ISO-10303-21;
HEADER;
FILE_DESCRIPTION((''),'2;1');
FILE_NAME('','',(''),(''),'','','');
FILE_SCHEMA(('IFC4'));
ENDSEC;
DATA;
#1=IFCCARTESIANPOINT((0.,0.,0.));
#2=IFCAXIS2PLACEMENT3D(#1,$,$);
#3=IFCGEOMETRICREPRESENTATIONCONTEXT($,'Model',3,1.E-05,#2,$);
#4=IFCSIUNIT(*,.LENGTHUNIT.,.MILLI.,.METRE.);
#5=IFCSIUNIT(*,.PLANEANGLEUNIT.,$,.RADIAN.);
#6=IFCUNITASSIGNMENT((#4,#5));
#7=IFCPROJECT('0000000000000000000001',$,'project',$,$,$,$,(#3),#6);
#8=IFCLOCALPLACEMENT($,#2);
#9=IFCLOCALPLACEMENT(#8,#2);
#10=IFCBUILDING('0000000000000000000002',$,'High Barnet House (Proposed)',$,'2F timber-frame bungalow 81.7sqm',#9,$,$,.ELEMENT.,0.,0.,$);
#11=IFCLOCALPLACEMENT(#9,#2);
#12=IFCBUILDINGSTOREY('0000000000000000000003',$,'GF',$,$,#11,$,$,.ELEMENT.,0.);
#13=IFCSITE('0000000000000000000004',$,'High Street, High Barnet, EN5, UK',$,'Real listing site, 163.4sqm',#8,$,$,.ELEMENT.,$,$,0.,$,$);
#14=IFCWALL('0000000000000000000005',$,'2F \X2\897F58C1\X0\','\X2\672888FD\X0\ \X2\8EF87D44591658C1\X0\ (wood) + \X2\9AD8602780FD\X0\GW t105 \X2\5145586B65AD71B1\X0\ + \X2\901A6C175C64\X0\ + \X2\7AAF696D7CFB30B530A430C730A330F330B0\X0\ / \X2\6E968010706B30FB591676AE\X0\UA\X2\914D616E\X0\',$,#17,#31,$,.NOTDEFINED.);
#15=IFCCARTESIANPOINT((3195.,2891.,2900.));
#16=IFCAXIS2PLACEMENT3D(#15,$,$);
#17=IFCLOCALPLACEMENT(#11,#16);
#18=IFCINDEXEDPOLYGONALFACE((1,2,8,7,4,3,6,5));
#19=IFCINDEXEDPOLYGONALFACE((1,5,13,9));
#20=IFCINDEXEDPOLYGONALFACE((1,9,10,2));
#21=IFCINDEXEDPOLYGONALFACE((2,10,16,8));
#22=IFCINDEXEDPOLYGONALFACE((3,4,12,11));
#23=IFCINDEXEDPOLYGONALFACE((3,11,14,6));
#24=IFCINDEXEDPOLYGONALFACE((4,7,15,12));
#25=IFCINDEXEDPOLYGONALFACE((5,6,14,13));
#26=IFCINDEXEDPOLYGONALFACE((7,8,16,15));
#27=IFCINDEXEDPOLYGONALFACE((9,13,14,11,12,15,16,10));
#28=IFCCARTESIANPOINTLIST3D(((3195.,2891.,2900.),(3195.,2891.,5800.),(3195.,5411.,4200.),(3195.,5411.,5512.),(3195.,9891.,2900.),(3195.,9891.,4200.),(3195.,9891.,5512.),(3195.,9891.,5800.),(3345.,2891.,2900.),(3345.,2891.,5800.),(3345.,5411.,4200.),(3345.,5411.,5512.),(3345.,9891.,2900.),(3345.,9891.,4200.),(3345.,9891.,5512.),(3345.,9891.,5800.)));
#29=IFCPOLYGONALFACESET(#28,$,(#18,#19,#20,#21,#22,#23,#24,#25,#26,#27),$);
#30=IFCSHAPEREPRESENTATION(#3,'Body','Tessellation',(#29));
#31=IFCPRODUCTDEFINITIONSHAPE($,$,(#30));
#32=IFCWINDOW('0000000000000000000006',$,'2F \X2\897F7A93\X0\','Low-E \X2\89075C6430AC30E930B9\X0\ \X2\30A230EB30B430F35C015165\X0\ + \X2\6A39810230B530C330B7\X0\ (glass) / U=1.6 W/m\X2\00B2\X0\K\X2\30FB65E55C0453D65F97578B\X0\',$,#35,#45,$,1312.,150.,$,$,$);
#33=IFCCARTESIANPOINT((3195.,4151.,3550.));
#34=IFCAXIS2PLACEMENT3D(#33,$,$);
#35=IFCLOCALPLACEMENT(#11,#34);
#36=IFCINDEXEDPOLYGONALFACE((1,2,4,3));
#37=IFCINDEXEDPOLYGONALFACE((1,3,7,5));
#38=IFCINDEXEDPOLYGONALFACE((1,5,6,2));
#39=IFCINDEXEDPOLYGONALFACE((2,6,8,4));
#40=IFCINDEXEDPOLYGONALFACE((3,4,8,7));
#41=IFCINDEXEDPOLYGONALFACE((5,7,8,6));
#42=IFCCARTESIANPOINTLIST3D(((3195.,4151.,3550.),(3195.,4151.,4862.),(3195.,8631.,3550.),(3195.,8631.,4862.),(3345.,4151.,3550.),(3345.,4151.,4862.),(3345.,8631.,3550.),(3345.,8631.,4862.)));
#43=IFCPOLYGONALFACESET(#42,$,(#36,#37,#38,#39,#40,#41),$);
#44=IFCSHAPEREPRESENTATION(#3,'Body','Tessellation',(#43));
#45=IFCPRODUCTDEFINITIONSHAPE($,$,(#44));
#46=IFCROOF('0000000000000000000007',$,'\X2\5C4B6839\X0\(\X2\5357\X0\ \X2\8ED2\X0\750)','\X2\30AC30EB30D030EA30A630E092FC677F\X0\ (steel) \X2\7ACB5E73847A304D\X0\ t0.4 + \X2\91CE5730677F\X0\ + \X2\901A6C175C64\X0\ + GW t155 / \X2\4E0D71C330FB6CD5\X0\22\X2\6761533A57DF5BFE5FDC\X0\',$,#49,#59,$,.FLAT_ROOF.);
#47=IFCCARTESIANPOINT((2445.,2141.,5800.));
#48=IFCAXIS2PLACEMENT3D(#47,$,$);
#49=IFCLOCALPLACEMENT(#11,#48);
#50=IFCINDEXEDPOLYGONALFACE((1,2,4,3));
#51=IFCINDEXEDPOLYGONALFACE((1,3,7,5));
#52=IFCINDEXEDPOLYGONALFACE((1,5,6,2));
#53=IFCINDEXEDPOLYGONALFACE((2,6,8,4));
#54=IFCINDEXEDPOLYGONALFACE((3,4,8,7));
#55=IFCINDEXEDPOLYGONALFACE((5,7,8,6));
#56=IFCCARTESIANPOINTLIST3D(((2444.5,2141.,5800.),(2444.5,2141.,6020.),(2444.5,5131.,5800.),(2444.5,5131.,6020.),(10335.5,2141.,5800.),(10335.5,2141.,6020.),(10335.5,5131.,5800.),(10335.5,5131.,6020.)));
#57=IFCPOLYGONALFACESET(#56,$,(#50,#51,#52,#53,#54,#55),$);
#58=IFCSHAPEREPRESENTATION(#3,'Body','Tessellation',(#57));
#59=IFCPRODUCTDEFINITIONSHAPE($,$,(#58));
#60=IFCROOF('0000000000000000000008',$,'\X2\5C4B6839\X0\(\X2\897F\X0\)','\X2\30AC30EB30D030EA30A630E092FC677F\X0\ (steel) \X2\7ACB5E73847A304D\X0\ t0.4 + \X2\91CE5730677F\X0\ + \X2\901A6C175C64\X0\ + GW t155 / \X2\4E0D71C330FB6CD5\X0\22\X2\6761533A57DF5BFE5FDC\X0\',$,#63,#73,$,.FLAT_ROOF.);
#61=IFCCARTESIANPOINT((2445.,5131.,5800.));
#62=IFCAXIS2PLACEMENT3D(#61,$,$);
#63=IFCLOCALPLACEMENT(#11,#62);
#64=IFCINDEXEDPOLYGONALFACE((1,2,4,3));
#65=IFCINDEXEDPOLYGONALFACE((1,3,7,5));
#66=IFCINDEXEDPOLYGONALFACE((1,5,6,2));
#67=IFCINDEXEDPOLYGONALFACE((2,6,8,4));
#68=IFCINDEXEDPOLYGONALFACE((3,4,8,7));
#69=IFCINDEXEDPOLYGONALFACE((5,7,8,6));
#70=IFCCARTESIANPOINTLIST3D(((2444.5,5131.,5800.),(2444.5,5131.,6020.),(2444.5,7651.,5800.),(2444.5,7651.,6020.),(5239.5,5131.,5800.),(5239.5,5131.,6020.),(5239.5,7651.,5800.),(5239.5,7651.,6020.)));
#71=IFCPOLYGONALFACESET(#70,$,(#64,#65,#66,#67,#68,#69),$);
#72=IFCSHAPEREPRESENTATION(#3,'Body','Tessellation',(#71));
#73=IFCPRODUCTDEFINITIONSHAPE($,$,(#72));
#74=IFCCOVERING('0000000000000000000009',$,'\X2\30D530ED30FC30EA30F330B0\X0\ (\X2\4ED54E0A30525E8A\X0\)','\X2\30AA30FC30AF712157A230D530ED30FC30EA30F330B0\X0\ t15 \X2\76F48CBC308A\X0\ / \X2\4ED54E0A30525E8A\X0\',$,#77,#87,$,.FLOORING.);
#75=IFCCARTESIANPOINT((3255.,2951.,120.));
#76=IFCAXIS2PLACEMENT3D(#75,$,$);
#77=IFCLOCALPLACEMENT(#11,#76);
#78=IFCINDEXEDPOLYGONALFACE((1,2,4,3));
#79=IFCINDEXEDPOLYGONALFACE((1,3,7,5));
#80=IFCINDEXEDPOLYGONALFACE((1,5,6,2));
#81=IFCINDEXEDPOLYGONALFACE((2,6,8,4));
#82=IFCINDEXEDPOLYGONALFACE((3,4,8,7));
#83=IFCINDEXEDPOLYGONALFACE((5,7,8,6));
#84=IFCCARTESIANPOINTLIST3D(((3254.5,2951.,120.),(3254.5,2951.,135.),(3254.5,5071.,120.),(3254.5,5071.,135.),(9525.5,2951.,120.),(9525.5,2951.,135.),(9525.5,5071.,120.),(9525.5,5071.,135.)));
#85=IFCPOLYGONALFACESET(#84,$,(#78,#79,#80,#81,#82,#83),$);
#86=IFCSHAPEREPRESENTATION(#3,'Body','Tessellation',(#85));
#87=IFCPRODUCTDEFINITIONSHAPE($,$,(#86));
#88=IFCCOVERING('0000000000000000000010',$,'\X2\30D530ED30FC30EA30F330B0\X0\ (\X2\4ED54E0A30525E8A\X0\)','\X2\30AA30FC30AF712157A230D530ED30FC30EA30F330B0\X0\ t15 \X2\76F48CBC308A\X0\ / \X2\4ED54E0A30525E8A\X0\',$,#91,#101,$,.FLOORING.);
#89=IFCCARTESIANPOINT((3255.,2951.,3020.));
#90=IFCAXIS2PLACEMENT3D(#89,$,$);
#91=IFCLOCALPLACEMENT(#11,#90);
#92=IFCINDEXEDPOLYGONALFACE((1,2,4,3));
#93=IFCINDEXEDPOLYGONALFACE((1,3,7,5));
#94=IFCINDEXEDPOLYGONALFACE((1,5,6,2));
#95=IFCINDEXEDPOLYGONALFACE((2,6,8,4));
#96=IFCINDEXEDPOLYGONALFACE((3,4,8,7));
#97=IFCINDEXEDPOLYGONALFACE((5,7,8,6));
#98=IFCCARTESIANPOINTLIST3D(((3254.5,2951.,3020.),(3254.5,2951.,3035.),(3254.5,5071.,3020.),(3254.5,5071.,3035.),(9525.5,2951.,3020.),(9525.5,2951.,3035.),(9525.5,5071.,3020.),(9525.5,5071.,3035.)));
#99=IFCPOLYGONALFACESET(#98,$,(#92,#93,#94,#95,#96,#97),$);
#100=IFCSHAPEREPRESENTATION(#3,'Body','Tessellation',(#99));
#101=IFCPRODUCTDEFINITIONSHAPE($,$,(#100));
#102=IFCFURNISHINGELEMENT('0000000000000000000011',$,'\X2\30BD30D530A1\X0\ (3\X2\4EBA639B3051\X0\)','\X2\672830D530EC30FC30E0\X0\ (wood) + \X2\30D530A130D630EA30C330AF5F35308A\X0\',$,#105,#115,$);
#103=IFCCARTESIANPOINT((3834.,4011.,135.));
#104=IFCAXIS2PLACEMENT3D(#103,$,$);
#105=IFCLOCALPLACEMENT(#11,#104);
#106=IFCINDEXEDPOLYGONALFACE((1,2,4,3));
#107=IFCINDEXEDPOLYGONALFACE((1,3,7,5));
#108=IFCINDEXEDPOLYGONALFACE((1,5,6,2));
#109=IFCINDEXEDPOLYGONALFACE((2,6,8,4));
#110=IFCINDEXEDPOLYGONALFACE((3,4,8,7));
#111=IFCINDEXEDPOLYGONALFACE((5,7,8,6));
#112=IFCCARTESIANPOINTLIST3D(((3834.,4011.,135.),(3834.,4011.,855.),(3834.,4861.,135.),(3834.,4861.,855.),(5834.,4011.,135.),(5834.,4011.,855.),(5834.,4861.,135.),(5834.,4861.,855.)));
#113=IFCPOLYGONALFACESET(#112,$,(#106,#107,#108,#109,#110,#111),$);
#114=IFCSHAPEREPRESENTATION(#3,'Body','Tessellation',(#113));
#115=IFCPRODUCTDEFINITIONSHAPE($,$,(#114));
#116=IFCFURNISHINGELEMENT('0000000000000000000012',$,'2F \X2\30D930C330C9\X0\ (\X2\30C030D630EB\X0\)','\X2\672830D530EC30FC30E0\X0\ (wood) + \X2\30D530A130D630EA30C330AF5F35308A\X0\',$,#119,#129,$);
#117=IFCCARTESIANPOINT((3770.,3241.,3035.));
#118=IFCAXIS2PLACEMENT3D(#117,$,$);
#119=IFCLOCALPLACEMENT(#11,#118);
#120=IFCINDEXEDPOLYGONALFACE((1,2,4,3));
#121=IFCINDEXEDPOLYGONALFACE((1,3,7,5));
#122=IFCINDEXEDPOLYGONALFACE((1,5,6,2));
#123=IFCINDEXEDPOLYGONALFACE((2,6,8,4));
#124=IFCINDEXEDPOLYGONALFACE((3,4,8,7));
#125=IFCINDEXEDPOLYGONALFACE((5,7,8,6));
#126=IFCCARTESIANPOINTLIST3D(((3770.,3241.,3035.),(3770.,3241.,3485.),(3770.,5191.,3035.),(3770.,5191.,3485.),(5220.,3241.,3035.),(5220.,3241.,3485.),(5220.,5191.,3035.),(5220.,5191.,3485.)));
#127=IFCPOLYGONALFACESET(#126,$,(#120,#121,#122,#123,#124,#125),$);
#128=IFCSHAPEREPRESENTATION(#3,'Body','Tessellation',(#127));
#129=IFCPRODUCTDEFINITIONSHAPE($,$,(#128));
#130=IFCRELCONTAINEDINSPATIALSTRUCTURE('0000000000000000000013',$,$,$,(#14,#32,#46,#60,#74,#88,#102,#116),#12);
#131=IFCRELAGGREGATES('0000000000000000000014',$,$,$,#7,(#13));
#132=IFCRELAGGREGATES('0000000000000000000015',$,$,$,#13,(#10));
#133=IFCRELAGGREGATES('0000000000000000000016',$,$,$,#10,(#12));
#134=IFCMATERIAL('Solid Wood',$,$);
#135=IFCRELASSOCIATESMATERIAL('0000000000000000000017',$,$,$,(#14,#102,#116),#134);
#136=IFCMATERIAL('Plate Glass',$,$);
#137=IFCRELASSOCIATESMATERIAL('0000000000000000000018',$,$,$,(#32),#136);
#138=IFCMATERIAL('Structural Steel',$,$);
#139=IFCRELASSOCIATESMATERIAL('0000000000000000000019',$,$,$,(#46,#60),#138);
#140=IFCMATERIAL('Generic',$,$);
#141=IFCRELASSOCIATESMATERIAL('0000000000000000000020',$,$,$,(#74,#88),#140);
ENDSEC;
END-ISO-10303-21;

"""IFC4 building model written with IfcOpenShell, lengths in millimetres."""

from ifc_helpers import new_model, si_unit, frame, frame_2d, origin, place, context, project, spatial, rectangle, extrude, material, element, fill, save


model = new_model("IFC4")

# Units and contexts
model_context = context("Model", 3, precision=1e-05, world=origin())
ifc_project = project(units=[si_unit("LENGTHUNIT", "METRE", prefix="MILLI"), si_unit("PLANEANGLEUNIT", "RADIAN")], contexts=[model_context])

# Site, building, storey
site_placement = place(None, origin())
site = spatial("IfcSite", under=ifc_project, at=site_placement, Name="High Street, High Barnet, EN5, UK", ObjectType="Real listing site, 163.4sqm", CompositionType="ELEMENT", RefElevation=0.0)
building_placement = place(site_placement, origin())
building = spatial("IfcBuilding", under=site, at=building_placement, Name="High Barnet House (Proposed)", ObjectType="2F timber-frame bungalow 81.7sqm", CompositionType="ELEMENT", ElevationOfRefHeight=0.0, ElevationOfTerrain=0.0)
storey_placement = place(building_placement, origin())
storey = spatial("IfcBuildingStorey", under=building, at=storey_placement, Name="GF", CompositionType="ELEMENT", Elevation=0.0)

# Shared definitions
ifc_material_1 = material(Name="Solid Wood")

# Shared definitions
ifc_material_2 = material(Name="Plate Glass")

# Wall, opening, window
wall_1_placement = place(storey_placement, frame((3195.0, 2891.0, 2900.0)))
wall_1 = element("IfcWall", 1, at=wall_1_placement, inside=storey, material=ifc_material_1, Name="2F 西壁", Description="木製 軸組外壁 (wood) + 高性能GW t105 充填断熱 + 通気層 + 窯業系サイディング / 準耐火・外皮UA配慮", PredefinedType="NOTDEFINED", context=model_context, shape_type="SweptSolid", body=[
    extrude(rectangle(XDim=150.0, YDim=7000.0, at=frame_2d((75.0, 3500.0))), frame((3195.0, 2891.0, 2900.0)), (0.0, 0.0, 1.0), 2900.0),
])
opening_1_placement = place(storey_placement, frame((3195.0, 4151.0, 3550.0)))
opening_1 = element("IfcOpeningElement", 2, at=opening_1_placement, cuts=wall_1, PredefinedType="NOTDEFINED", context=model_context, shape_type="SweptSolid", body=[
    extrude(rectangle(XDim=150.0, YDim=4480.0, at=frame_2d((75.0, 2240.0))), frame((3195.0, 4151.0, 3550.0)), (0.0, 0.0, 1.0), 1312.0),
])
window_1_placement = place(storey_placement, frame((3195.0, 4151.0, 3550.0)))
window_1 = element("IfcWindow", 3, at=window_1_placement, inside=storey, material=ifc_material_2, Name="2F 西窓", Description="Low-E 複層ガラス アルゴン封入 + 樹脂サッシ (glass) / U=1.6 W/m²K・日射取得型", OverallHeight=1312.0, OverallWidth=150.0, context=model_context, shape_type="SweptSolid", body=[
    extrude(rectangle(XDim=150.0, YDim=4480.0, at=frame_2d((75.0, 2240.0))), frame((3195.0, 4151.0, 3550.0)), (0.0, 0.0, 1.0), 1312.0),
])
fill(opening_1, window_1)

# Roofs
ifc_material_3 = material(Name="Structural Steel")
roof_1_placement = place(storey_placement, frame((2445.0, 2141.0, 5800.0)))
element("IfcRoof", 4, at=roof_1_placement, inside=storey, material=ifc_material_3, Name="屋根(南 軒750)", Description="ガルバリウム鋼板 (steel) 立平葺き t0.4 + 野地板 + 通気層 + GW t155 / 不燃・法22条区域対応", PredefinedType="FLAT_ROOF", context=model_context, shape_type="SweptSolid", body=[
    extrude(rectangle(XDim=7891.0, YDim=2990.0, at=frame_2d((3945.0, 1495.0))), frame((2445.0, 2141.0, 5800.0)), (0.0, 0.0, 1.0), 220.0),
])
roof_2_placement = place(storey_placement, frame((2445.0, 5131.0, 5800.0)))
element("IfcRoof", 5, at=roof_2_placement, inside=storey, material=ifc_material_3, Name="屋根(西)", Description="ガルバリウム鋼板 (steel) 立平葺き t0.4 + 野地板 + 通気層 + GW t155 / 不燃・法22条区域対応", PredefinedType="FLAT_ROOF", context=model_context, shape_type="SweptSolid", body=[
    extrude(rectangle(XDim=2795.0, YDim=2520.0, at=frame_2d((1397.0, 1260.0))), frame((2445.0, 5131.0, 5800.0)), (0.0, 0.0, 1.0), 220.0),
])

# Coverings
ifc_material_4 = material(Name="Generic")
covering_1_placement = place(storey_placement, frame((3255.0, 2951.0, 120.0)))
element("IfcCovering", 6, at=covering_1_placement, inside=storey, material=ifc_material_4, Name="フローリング (仕上げ床)", Description="オーク無垢フローリング t15 直貼り / 仕上げ床", PredefinedType="FLOORING", context=model_context, shape_type="SweptSolid", body=[
    extrude(rectangle(XDim=6271.0, YDim=2120.0, at=frame_2d((3135.0, 1060.0))), frame((3255.0, 2951.0, 120.0)), (0.0, 0.0, 1.0), 15.0),
])
covering_2_placement = place(storey_placement, frame((3255.0, 2951.0, 3020.0)))
element("IfcCovering", 7, at=covering_2_placement, inside=storey, material=ifc_material_4, Name="フローリング (仕上げ床)", Description="オーク無垢フローリング t15 直貼り / 仕上げ床", PredefinedType="FLOORING", context=model_context, shape_type="SweptSolid", body=[
    extrude(rectangle(XDim=6271.0, YDim=2120.0, at=frame_2d((3135.0, 1060.0))), frame((3255.0, 2951.0, 3020.0)), (0.0, 0.0, 1.0), 15.0),
])

# Furnishing elements
furnishing_1_placement = place(storey_placement, frame((3834.0, 4011.0, 135.0)))
element("IfcFurnishingElement", 8, at=furnishing_1_placement, inside=storey, material=ifc_material_1, Name="ソファ (3人掛け)", Description="木フレーム (wood) + ファブリック張り", context=model_context, shape_type="SweptSolid", body=[
    extrude(rectangle(XDim=2000.0, YDim=850.0, at=frame_2d((1000.0, 425.0))), frame((3834.0, 4011.0, 135.0)), (0.0, 0.0, 1.0), 720.0),
])
furnishing_2_placement = place(storey_placement, frame((3770.0, 3241.0, 3035.0)))
element("IfcFurnishingElement", 9, at=furnishing_2_placement, inside=storey, material=ifc_material_1, Name="2F ベッド (ダブル)", Description="木フレーム (wood) + ファブリック張り", context=model_context, shape_type="SweptSolid", body=[
    extrude(rectangle(XDim=1450.0, YDim=1950.0, at=frame_2d((725.0, 975.0))), frame((3770.0, 3241.0, 3035.0)), (0.0, 0.0, 1.0), 450.0),
])

save(model, "model.ifc")
